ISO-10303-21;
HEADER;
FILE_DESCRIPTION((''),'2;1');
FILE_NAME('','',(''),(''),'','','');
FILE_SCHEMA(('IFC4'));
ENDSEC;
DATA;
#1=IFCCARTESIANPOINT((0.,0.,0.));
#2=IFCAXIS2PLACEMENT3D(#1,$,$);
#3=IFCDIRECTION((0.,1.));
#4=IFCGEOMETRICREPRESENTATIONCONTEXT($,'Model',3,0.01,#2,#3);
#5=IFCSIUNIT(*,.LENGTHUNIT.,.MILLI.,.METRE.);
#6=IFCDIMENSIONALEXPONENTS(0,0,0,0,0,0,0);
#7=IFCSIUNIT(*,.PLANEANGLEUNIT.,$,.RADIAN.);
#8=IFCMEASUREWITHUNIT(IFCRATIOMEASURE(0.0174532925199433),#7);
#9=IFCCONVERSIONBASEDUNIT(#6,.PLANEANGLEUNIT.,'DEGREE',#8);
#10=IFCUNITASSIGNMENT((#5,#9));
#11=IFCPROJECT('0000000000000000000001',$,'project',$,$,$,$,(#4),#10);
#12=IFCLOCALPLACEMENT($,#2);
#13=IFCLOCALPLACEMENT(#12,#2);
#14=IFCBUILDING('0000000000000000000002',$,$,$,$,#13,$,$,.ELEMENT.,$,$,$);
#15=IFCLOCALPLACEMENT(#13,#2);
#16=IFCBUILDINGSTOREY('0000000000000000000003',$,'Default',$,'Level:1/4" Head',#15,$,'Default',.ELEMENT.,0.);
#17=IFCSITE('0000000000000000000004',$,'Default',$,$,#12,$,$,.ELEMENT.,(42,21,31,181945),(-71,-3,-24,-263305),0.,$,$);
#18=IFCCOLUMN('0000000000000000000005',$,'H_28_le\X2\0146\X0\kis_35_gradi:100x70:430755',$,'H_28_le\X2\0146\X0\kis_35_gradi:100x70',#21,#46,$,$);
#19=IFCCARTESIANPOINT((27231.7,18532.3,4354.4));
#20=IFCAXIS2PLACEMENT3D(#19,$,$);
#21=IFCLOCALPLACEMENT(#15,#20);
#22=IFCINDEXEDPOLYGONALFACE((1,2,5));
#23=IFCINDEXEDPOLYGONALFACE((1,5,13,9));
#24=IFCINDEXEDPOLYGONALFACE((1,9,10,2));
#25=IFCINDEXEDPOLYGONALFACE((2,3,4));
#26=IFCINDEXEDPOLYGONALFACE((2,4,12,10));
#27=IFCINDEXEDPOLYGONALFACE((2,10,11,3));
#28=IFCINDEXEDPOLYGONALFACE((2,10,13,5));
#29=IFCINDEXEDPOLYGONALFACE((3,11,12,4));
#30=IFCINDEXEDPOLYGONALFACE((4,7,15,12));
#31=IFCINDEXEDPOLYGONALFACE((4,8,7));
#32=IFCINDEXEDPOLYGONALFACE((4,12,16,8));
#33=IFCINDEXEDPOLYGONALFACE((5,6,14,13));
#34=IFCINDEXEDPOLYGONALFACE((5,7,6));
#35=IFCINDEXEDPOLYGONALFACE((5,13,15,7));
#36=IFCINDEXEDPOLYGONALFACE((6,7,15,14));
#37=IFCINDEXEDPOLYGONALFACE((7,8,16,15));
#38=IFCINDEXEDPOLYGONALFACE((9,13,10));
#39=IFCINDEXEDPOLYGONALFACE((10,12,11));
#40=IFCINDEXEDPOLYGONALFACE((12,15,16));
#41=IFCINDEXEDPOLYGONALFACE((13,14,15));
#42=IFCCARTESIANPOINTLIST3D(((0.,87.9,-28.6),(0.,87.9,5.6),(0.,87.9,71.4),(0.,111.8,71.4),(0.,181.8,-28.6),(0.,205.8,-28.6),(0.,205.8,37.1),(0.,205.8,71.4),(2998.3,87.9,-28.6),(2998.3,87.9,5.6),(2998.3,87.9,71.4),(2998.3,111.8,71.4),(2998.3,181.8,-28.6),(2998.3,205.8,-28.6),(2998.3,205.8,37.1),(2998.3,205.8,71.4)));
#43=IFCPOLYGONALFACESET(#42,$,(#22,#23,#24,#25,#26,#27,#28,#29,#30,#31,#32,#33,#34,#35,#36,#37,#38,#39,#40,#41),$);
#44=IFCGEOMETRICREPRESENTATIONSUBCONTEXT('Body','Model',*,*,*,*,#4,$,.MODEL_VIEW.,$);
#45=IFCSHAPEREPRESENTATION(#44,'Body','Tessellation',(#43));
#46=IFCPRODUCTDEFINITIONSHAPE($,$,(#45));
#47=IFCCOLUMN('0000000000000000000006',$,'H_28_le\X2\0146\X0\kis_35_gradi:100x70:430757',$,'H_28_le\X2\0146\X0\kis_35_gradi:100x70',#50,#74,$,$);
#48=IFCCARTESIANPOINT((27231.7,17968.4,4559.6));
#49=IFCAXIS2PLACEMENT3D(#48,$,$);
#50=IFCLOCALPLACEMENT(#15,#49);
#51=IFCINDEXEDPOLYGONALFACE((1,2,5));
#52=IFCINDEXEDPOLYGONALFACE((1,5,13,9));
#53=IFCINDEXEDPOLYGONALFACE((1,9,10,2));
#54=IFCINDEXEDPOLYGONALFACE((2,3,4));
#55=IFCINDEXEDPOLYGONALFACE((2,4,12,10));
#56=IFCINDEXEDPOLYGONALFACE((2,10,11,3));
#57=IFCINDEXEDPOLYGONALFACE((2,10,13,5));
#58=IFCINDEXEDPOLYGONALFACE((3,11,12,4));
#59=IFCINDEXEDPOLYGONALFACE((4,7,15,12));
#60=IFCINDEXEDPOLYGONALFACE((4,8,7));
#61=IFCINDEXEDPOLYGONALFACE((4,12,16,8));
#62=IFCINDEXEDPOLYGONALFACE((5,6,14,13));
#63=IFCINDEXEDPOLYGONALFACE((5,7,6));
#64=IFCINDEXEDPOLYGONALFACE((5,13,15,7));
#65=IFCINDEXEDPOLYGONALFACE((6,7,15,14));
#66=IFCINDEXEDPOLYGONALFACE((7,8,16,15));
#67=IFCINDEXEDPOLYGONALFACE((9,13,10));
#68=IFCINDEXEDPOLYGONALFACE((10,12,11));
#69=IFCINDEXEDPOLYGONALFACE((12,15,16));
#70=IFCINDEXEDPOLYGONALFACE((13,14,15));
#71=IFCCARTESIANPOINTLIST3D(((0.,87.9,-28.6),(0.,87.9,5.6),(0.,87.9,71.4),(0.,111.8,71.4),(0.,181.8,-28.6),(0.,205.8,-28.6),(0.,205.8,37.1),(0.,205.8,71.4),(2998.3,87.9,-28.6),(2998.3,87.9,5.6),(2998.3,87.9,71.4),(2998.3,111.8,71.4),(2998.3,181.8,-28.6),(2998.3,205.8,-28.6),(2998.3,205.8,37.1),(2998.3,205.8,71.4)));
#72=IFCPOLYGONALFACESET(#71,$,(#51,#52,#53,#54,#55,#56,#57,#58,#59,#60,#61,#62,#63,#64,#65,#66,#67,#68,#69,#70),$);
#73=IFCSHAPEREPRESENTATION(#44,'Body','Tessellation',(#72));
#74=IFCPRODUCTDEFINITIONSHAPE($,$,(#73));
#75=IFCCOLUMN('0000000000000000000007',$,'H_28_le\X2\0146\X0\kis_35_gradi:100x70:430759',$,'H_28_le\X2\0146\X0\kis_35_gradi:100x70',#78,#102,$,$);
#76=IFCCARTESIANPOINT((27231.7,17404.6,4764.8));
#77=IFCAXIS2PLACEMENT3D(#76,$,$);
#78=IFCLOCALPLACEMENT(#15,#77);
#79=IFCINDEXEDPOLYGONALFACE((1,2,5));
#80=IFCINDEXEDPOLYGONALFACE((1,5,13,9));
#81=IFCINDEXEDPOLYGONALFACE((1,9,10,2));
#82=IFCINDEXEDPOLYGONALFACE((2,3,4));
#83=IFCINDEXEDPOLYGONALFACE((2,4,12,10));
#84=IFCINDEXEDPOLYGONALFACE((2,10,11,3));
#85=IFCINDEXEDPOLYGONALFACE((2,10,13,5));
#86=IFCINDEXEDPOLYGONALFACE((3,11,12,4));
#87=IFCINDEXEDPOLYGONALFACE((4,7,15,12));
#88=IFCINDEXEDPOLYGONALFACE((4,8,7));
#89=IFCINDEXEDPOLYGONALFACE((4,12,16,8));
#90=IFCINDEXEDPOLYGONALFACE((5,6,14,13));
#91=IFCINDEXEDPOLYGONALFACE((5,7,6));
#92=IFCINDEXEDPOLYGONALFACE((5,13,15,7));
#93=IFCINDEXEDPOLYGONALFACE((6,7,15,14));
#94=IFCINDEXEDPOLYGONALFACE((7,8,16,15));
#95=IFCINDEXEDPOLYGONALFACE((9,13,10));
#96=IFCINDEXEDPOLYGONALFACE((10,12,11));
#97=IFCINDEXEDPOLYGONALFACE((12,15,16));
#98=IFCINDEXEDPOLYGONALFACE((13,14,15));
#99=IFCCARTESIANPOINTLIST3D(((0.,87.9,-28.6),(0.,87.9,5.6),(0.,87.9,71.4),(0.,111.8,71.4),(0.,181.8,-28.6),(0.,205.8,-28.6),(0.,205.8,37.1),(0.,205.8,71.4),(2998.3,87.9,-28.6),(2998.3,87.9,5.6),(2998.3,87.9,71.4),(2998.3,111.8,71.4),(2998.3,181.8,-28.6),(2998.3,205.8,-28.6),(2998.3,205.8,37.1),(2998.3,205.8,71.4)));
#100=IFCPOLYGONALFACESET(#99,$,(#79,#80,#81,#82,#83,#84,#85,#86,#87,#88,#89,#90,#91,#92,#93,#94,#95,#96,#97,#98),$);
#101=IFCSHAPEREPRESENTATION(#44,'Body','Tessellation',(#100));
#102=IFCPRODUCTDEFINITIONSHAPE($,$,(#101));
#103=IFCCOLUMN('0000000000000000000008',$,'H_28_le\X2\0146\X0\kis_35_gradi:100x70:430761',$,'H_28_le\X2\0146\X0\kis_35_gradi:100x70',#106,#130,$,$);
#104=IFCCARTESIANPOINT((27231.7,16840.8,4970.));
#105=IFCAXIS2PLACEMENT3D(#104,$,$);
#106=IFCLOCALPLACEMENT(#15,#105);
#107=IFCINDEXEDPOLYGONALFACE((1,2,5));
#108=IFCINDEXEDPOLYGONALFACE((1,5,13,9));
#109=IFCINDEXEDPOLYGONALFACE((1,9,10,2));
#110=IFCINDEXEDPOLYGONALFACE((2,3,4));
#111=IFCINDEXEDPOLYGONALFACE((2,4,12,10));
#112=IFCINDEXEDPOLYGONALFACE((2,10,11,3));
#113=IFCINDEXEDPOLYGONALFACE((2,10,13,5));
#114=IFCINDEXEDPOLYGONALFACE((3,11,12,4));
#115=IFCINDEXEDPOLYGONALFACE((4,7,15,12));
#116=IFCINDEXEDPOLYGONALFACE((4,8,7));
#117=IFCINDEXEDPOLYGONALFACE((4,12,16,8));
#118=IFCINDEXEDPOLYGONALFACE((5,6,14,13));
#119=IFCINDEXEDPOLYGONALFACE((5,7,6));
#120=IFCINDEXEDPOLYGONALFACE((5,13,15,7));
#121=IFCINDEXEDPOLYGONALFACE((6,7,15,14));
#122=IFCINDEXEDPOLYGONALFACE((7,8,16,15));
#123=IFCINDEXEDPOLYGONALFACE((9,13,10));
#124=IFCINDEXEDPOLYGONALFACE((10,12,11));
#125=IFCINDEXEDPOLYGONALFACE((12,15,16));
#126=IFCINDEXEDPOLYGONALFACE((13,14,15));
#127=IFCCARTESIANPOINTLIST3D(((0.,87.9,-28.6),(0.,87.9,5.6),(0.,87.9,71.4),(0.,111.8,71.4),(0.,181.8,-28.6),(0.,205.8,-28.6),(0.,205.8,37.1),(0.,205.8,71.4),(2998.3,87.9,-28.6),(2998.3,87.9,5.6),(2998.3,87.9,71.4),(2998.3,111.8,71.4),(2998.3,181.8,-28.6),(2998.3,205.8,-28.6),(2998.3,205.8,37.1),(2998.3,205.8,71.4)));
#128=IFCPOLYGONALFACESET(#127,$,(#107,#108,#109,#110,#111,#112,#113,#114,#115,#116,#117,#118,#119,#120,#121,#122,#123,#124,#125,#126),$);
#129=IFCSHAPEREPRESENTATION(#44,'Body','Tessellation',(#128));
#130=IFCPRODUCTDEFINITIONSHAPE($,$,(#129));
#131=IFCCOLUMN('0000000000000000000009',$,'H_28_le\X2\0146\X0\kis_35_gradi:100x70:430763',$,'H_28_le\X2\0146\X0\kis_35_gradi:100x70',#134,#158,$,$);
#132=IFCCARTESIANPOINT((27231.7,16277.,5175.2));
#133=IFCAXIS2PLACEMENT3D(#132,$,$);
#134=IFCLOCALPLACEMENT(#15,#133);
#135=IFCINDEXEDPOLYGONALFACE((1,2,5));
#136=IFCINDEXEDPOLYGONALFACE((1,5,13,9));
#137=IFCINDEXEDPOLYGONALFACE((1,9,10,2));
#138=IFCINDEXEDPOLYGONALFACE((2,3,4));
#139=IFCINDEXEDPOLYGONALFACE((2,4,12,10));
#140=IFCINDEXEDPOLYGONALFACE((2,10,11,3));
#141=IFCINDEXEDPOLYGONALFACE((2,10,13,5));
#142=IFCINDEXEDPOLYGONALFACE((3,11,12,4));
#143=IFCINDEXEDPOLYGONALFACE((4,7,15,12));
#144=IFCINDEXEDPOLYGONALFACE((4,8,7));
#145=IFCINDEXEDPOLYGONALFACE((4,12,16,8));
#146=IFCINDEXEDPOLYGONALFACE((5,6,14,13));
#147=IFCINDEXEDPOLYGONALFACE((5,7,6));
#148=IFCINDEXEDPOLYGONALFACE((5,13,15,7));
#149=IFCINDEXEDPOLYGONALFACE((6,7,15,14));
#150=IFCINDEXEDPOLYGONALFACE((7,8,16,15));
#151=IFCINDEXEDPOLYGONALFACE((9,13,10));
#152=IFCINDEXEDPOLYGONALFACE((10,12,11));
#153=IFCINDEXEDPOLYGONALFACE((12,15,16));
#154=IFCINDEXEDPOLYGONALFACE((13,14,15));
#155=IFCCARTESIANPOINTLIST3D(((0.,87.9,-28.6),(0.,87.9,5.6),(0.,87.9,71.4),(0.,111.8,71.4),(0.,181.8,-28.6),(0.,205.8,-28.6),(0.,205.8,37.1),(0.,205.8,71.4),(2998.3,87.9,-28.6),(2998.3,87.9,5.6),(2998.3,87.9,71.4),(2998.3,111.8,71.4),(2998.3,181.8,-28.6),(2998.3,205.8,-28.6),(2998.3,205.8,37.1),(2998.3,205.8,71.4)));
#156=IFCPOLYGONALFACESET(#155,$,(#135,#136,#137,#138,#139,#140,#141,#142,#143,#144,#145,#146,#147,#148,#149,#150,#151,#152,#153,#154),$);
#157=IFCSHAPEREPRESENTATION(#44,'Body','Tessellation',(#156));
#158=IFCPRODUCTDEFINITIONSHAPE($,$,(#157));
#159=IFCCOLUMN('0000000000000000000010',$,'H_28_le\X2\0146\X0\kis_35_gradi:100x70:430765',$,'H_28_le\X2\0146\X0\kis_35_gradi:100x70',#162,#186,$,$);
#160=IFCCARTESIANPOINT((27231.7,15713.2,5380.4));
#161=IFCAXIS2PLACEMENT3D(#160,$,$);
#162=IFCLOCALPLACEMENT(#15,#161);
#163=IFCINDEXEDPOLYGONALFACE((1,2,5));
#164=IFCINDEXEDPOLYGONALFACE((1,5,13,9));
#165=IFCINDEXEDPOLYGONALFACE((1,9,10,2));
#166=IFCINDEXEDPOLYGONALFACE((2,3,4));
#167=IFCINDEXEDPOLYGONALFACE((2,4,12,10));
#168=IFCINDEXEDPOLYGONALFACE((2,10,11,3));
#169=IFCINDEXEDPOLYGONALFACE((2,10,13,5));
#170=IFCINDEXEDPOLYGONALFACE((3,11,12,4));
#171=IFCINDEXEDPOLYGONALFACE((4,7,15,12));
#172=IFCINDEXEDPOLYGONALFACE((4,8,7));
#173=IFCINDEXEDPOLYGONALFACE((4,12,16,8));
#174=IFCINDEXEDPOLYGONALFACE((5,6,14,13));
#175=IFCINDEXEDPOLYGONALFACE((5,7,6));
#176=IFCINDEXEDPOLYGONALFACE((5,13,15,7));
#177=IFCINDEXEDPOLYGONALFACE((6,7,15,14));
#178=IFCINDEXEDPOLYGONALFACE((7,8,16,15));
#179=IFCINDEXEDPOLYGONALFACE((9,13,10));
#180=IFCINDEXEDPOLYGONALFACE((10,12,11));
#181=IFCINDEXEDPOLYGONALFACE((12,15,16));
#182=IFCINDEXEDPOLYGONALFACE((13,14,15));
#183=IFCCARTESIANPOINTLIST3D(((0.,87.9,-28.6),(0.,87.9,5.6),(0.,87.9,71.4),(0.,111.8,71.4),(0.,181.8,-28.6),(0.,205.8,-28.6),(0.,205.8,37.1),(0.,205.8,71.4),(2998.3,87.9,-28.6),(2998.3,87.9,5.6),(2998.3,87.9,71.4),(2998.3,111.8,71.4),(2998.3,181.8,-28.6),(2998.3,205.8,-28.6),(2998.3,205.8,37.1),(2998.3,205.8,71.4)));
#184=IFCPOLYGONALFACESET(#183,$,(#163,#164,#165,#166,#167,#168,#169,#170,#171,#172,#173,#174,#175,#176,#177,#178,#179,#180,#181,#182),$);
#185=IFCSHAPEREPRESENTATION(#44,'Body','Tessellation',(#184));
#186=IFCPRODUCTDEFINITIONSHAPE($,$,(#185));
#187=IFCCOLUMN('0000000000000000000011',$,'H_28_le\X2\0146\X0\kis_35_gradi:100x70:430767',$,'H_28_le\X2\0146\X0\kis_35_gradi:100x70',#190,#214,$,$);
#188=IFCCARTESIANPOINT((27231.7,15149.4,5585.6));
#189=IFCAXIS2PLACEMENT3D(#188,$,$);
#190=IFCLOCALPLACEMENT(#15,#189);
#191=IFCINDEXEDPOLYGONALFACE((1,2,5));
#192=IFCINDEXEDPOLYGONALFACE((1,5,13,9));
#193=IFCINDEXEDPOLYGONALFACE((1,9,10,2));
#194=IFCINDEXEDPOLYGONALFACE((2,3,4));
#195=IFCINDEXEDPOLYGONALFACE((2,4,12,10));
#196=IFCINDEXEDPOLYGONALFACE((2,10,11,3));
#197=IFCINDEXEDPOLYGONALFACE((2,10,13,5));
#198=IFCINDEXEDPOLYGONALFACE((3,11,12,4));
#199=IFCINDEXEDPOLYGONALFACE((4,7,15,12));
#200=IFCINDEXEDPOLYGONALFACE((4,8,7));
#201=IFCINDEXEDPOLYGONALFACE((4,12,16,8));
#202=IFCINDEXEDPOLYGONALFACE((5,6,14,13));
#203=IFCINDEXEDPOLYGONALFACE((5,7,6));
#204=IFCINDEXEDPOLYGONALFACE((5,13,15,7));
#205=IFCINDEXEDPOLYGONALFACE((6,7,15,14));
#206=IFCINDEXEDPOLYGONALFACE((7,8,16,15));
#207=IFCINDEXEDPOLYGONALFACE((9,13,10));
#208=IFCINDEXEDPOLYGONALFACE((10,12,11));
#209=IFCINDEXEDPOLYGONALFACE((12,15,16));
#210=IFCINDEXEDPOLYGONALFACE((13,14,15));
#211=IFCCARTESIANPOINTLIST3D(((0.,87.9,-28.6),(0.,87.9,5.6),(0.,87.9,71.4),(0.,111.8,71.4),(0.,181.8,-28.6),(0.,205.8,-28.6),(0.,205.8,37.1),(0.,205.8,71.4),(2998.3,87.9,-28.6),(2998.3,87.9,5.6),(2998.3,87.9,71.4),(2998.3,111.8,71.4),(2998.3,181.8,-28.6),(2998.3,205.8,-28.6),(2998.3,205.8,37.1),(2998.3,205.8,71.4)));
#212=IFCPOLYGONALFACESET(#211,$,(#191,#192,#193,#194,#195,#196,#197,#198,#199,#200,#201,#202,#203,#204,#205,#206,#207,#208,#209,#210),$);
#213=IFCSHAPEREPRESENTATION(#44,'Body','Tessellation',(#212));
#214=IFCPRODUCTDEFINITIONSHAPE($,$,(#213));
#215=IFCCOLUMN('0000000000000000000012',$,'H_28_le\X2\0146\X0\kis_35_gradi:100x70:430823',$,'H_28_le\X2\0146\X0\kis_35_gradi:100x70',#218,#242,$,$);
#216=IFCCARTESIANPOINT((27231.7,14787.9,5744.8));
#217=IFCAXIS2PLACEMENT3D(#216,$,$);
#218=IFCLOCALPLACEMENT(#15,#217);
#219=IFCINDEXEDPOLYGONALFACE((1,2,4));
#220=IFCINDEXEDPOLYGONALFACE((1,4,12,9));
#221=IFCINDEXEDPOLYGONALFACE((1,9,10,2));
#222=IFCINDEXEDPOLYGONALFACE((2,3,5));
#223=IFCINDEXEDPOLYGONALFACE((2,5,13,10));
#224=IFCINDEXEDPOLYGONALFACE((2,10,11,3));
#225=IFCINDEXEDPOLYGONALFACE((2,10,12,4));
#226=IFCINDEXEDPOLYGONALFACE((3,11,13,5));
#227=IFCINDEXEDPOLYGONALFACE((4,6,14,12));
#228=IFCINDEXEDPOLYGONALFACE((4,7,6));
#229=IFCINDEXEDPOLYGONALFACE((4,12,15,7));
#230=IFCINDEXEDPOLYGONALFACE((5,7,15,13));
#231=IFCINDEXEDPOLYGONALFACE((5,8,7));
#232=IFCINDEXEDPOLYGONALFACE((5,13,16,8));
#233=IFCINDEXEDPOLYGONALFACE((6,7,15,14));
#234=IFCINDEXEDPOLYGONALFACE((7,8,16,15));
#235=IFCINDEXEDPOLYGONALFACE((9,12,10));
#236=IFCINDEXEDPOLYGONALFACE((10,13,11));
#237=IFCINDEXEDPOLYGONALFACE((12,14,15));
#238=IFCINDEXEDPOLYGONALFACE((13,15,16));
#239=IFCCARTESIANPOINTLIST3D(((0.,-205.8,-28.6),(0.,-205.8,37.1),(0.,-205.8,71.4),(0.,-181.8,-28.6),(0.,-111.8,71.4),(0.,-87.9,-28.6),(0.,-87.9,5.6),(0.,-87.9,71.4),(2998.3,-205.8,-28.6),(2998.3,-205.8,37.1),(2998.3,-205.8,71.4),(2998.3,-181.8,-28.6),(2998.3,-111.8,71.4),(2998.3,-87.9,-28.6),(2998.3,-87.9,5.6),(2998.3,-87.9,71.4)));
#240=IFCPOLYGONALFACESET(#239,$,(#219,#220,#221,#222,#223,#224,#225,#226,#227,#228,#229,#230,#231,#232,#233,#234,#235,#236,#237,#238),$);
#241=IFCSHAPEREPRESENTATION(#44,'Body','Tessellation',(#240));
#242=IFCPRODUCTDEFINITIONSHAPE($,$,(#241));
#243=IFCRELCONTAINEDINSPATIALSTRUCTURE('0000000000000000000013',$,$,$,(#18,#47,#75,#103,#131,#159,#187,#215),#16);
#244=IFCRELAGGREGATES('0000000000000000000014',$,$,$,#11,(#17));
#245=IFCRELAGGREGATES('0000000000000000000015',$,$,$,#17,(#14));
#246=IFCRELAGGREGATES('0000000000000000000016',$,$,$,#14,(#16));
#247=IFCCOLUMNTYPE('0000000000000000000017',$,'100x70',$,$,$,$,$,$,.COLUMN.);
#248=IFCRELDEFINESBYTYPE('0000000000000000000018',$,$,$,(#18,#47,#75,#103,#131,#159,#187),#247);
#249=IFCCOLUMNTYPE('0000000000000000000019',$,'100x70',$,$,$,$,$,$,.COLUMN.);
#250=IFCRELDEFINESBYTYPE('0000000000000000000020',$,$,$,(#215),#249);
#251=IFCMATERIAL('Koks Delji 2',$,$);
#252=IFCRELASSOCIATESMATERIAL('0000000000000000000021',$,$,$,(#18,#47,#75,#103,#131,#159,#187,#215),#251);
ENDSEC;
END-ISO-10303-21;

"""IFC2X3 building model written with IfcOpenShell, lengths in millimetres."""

from ifc_helpers import new_model, entity, si_unit, converted_unit, direction, frame, frame_2d, origin, place, context, subcontext, project, spatial, rectangle, extrude, boolean, source, transform, mapped, material, type_object, type_shapes, element, save


model = new_model("IFC2X3")

# Units and contexts
model_context = context("Model", 3, precision=0.01, world=origin(), true_north=direction((0.0, 1.0)))
body_context = subcontext(model_context, "Body", "Model", "MODEL_VIEW")
ifc_project = project(units=[si_unit("LENGTHUNIT", "METRE", prefix="MILLI"), converted_unit("PLANEANGLEUNIT", "DEGREE", entity("IfcRatioMeasure", 0.0174532925199433), si_unit("PLANEANGLEUNIT", "RADIAN"), dimensions=[0, 0, 0, 0, 0, 0, 0])], contexts=[model_context])

# Site, building, storey
site_placement = place(None, origin())
site = spatial("IfcSite", under=ifc_project, at=site_placement, Name="Default", CompositionType="ELEMENT", RefLatitude=(42, 21, 31, 181945), RefLongitude=(-71, -3, -24, -263305), RefElevation=0.0)
building_placement = place(site_placement, origin())
building = spatial("IfcBuilding", under=site, at=building_placement, CompositionType="ELEMENT")
storey_placement = place(building_placement, origin())
storey = spatial("IfcBuildingStorey", under=building, at=storey_placement, Name="Default", ObjectType="Level:1/4\" Head", LongName="Default", CompositionType="ELEMENT", Elevation=0.0)

# Columns
ifc_material_1 = material(Name="Koks Delji 2")
column_type_1 = type_object("IfcColumnType", Name="100x70", PredefinedType="COLUMN")
shared_shape_1 = source(origin(), body_context, "Body", "CSG", [
    boolean("DIFFERENCE", extrude(rectangle(XDim=2998.3, YDim=117.9, at=frame_2d((0.0, 0.0), x_axis=(1.0, 0.0))), frame((1499.1, 146.8, -28.6)), (0.0, 0.0, 1.0), 100.0), extrude(rectangle(XDim=70.0, YDim=100.0, at=frame_2d((0.0, 0.0), x_axis=(0.0, 1.0))), frame((2998.3, 146.8, 21.4), z_axis=(1.0, 0.0, 0.0), x_axis=(0.0, 0.939693, -0.34202)), (0.0, 0.0, -1.0), 2998.3)),
])
type_shapes(column_type_1, [shared_shape_1])
for number, where, name in (
    (1, (27231.7, 18532.3, 4354.4), "H_28_leņkis_35_gradi:100x70:430755"),
    (2, (27231.7, 17968.4, 4559.6), "H_28_leņkis_35_gradi:100x70:430757"),
    (3, (27231.7, 17404.6, 4764.8), "H_28_leņkis_35_gradi:100x70:430759"),
    (4, (27231.7, 16840.8, 4970.0), "H_28_leņkis_35_gradi:100x70:430761"),
    (5, (27231.7, 16277.0, 5175.2), "H_28_leņkis_35_gradi:100x70:430763"),
    (6, (27231.7, 15713.2, 5380.4), "H_28_leņkis_35_gradi:100x70:430765"),
    (7, (27231.7, 15149.4, 5585.6), "H_28_leņkis_35_gradi:100x70:430767"),
):
    element("IfcColumn", number, at=place(storey_placement, frame(where)), inside=storey, type_object=column_type_1, material=ifc_material_1, Name=name, ObjectType="H_28_leņkis_35_gradi:100x70", context=body_context, shape_type="MappedRepresentation", body=[
        mapped(shared_shape_1, transform((0.0, 0.0, 0.0), scale=1.0)),
    ])
column_type_2 = type_object("IfcColumnType", Name="100x70", PredefinedType="COLUMN")
shared_shape_2 = source(origin(), body_context, "Body", "CSG", [
    boolean("DIFFERENCE", extrude(rectangle(XDim=2998.3, YDim=117.9, at=frame_2d((0.0, 0.0), x_axis=(1.0, 0.0))), frame((1499.1, -146.8, -28.6)), (0.0, 0.0, 1.0), 100.0), extrude(rectangle(XDim=70.0, YDim=100.0, at=frame_2d((0.0, 0.0), x_axis=(0.0, 1.0))), frame((0.0, -146.8, 21.4), z_axis=(-1.0, 0.0, 0.0), x_axis=(0.0, -0.939693, -0.34202)), (0.0, 0.0, -1.0), 2998.3)),
])
type_shapes(column_type_2, [shared_shape_2])
column_placement = place(storey_placement, frame((27231.7, 14787.9, 5744.8)))
element("IfcColumn", 8, at=column_placement, inside=storey, type_object=column_type_2, material=ifc_material_1, Name="H_28_leņkis_35_gradi:100x70:430823", ObjectType="H_28_leņkis_35_gradi:100x70", context=body_context, shape_type="MappedRepresentation", body=[
    mapped(shared_shape_2, transform((0.0, 0.0, 0.0), scale=1.0)),
])

save(model, "model.ifc")
